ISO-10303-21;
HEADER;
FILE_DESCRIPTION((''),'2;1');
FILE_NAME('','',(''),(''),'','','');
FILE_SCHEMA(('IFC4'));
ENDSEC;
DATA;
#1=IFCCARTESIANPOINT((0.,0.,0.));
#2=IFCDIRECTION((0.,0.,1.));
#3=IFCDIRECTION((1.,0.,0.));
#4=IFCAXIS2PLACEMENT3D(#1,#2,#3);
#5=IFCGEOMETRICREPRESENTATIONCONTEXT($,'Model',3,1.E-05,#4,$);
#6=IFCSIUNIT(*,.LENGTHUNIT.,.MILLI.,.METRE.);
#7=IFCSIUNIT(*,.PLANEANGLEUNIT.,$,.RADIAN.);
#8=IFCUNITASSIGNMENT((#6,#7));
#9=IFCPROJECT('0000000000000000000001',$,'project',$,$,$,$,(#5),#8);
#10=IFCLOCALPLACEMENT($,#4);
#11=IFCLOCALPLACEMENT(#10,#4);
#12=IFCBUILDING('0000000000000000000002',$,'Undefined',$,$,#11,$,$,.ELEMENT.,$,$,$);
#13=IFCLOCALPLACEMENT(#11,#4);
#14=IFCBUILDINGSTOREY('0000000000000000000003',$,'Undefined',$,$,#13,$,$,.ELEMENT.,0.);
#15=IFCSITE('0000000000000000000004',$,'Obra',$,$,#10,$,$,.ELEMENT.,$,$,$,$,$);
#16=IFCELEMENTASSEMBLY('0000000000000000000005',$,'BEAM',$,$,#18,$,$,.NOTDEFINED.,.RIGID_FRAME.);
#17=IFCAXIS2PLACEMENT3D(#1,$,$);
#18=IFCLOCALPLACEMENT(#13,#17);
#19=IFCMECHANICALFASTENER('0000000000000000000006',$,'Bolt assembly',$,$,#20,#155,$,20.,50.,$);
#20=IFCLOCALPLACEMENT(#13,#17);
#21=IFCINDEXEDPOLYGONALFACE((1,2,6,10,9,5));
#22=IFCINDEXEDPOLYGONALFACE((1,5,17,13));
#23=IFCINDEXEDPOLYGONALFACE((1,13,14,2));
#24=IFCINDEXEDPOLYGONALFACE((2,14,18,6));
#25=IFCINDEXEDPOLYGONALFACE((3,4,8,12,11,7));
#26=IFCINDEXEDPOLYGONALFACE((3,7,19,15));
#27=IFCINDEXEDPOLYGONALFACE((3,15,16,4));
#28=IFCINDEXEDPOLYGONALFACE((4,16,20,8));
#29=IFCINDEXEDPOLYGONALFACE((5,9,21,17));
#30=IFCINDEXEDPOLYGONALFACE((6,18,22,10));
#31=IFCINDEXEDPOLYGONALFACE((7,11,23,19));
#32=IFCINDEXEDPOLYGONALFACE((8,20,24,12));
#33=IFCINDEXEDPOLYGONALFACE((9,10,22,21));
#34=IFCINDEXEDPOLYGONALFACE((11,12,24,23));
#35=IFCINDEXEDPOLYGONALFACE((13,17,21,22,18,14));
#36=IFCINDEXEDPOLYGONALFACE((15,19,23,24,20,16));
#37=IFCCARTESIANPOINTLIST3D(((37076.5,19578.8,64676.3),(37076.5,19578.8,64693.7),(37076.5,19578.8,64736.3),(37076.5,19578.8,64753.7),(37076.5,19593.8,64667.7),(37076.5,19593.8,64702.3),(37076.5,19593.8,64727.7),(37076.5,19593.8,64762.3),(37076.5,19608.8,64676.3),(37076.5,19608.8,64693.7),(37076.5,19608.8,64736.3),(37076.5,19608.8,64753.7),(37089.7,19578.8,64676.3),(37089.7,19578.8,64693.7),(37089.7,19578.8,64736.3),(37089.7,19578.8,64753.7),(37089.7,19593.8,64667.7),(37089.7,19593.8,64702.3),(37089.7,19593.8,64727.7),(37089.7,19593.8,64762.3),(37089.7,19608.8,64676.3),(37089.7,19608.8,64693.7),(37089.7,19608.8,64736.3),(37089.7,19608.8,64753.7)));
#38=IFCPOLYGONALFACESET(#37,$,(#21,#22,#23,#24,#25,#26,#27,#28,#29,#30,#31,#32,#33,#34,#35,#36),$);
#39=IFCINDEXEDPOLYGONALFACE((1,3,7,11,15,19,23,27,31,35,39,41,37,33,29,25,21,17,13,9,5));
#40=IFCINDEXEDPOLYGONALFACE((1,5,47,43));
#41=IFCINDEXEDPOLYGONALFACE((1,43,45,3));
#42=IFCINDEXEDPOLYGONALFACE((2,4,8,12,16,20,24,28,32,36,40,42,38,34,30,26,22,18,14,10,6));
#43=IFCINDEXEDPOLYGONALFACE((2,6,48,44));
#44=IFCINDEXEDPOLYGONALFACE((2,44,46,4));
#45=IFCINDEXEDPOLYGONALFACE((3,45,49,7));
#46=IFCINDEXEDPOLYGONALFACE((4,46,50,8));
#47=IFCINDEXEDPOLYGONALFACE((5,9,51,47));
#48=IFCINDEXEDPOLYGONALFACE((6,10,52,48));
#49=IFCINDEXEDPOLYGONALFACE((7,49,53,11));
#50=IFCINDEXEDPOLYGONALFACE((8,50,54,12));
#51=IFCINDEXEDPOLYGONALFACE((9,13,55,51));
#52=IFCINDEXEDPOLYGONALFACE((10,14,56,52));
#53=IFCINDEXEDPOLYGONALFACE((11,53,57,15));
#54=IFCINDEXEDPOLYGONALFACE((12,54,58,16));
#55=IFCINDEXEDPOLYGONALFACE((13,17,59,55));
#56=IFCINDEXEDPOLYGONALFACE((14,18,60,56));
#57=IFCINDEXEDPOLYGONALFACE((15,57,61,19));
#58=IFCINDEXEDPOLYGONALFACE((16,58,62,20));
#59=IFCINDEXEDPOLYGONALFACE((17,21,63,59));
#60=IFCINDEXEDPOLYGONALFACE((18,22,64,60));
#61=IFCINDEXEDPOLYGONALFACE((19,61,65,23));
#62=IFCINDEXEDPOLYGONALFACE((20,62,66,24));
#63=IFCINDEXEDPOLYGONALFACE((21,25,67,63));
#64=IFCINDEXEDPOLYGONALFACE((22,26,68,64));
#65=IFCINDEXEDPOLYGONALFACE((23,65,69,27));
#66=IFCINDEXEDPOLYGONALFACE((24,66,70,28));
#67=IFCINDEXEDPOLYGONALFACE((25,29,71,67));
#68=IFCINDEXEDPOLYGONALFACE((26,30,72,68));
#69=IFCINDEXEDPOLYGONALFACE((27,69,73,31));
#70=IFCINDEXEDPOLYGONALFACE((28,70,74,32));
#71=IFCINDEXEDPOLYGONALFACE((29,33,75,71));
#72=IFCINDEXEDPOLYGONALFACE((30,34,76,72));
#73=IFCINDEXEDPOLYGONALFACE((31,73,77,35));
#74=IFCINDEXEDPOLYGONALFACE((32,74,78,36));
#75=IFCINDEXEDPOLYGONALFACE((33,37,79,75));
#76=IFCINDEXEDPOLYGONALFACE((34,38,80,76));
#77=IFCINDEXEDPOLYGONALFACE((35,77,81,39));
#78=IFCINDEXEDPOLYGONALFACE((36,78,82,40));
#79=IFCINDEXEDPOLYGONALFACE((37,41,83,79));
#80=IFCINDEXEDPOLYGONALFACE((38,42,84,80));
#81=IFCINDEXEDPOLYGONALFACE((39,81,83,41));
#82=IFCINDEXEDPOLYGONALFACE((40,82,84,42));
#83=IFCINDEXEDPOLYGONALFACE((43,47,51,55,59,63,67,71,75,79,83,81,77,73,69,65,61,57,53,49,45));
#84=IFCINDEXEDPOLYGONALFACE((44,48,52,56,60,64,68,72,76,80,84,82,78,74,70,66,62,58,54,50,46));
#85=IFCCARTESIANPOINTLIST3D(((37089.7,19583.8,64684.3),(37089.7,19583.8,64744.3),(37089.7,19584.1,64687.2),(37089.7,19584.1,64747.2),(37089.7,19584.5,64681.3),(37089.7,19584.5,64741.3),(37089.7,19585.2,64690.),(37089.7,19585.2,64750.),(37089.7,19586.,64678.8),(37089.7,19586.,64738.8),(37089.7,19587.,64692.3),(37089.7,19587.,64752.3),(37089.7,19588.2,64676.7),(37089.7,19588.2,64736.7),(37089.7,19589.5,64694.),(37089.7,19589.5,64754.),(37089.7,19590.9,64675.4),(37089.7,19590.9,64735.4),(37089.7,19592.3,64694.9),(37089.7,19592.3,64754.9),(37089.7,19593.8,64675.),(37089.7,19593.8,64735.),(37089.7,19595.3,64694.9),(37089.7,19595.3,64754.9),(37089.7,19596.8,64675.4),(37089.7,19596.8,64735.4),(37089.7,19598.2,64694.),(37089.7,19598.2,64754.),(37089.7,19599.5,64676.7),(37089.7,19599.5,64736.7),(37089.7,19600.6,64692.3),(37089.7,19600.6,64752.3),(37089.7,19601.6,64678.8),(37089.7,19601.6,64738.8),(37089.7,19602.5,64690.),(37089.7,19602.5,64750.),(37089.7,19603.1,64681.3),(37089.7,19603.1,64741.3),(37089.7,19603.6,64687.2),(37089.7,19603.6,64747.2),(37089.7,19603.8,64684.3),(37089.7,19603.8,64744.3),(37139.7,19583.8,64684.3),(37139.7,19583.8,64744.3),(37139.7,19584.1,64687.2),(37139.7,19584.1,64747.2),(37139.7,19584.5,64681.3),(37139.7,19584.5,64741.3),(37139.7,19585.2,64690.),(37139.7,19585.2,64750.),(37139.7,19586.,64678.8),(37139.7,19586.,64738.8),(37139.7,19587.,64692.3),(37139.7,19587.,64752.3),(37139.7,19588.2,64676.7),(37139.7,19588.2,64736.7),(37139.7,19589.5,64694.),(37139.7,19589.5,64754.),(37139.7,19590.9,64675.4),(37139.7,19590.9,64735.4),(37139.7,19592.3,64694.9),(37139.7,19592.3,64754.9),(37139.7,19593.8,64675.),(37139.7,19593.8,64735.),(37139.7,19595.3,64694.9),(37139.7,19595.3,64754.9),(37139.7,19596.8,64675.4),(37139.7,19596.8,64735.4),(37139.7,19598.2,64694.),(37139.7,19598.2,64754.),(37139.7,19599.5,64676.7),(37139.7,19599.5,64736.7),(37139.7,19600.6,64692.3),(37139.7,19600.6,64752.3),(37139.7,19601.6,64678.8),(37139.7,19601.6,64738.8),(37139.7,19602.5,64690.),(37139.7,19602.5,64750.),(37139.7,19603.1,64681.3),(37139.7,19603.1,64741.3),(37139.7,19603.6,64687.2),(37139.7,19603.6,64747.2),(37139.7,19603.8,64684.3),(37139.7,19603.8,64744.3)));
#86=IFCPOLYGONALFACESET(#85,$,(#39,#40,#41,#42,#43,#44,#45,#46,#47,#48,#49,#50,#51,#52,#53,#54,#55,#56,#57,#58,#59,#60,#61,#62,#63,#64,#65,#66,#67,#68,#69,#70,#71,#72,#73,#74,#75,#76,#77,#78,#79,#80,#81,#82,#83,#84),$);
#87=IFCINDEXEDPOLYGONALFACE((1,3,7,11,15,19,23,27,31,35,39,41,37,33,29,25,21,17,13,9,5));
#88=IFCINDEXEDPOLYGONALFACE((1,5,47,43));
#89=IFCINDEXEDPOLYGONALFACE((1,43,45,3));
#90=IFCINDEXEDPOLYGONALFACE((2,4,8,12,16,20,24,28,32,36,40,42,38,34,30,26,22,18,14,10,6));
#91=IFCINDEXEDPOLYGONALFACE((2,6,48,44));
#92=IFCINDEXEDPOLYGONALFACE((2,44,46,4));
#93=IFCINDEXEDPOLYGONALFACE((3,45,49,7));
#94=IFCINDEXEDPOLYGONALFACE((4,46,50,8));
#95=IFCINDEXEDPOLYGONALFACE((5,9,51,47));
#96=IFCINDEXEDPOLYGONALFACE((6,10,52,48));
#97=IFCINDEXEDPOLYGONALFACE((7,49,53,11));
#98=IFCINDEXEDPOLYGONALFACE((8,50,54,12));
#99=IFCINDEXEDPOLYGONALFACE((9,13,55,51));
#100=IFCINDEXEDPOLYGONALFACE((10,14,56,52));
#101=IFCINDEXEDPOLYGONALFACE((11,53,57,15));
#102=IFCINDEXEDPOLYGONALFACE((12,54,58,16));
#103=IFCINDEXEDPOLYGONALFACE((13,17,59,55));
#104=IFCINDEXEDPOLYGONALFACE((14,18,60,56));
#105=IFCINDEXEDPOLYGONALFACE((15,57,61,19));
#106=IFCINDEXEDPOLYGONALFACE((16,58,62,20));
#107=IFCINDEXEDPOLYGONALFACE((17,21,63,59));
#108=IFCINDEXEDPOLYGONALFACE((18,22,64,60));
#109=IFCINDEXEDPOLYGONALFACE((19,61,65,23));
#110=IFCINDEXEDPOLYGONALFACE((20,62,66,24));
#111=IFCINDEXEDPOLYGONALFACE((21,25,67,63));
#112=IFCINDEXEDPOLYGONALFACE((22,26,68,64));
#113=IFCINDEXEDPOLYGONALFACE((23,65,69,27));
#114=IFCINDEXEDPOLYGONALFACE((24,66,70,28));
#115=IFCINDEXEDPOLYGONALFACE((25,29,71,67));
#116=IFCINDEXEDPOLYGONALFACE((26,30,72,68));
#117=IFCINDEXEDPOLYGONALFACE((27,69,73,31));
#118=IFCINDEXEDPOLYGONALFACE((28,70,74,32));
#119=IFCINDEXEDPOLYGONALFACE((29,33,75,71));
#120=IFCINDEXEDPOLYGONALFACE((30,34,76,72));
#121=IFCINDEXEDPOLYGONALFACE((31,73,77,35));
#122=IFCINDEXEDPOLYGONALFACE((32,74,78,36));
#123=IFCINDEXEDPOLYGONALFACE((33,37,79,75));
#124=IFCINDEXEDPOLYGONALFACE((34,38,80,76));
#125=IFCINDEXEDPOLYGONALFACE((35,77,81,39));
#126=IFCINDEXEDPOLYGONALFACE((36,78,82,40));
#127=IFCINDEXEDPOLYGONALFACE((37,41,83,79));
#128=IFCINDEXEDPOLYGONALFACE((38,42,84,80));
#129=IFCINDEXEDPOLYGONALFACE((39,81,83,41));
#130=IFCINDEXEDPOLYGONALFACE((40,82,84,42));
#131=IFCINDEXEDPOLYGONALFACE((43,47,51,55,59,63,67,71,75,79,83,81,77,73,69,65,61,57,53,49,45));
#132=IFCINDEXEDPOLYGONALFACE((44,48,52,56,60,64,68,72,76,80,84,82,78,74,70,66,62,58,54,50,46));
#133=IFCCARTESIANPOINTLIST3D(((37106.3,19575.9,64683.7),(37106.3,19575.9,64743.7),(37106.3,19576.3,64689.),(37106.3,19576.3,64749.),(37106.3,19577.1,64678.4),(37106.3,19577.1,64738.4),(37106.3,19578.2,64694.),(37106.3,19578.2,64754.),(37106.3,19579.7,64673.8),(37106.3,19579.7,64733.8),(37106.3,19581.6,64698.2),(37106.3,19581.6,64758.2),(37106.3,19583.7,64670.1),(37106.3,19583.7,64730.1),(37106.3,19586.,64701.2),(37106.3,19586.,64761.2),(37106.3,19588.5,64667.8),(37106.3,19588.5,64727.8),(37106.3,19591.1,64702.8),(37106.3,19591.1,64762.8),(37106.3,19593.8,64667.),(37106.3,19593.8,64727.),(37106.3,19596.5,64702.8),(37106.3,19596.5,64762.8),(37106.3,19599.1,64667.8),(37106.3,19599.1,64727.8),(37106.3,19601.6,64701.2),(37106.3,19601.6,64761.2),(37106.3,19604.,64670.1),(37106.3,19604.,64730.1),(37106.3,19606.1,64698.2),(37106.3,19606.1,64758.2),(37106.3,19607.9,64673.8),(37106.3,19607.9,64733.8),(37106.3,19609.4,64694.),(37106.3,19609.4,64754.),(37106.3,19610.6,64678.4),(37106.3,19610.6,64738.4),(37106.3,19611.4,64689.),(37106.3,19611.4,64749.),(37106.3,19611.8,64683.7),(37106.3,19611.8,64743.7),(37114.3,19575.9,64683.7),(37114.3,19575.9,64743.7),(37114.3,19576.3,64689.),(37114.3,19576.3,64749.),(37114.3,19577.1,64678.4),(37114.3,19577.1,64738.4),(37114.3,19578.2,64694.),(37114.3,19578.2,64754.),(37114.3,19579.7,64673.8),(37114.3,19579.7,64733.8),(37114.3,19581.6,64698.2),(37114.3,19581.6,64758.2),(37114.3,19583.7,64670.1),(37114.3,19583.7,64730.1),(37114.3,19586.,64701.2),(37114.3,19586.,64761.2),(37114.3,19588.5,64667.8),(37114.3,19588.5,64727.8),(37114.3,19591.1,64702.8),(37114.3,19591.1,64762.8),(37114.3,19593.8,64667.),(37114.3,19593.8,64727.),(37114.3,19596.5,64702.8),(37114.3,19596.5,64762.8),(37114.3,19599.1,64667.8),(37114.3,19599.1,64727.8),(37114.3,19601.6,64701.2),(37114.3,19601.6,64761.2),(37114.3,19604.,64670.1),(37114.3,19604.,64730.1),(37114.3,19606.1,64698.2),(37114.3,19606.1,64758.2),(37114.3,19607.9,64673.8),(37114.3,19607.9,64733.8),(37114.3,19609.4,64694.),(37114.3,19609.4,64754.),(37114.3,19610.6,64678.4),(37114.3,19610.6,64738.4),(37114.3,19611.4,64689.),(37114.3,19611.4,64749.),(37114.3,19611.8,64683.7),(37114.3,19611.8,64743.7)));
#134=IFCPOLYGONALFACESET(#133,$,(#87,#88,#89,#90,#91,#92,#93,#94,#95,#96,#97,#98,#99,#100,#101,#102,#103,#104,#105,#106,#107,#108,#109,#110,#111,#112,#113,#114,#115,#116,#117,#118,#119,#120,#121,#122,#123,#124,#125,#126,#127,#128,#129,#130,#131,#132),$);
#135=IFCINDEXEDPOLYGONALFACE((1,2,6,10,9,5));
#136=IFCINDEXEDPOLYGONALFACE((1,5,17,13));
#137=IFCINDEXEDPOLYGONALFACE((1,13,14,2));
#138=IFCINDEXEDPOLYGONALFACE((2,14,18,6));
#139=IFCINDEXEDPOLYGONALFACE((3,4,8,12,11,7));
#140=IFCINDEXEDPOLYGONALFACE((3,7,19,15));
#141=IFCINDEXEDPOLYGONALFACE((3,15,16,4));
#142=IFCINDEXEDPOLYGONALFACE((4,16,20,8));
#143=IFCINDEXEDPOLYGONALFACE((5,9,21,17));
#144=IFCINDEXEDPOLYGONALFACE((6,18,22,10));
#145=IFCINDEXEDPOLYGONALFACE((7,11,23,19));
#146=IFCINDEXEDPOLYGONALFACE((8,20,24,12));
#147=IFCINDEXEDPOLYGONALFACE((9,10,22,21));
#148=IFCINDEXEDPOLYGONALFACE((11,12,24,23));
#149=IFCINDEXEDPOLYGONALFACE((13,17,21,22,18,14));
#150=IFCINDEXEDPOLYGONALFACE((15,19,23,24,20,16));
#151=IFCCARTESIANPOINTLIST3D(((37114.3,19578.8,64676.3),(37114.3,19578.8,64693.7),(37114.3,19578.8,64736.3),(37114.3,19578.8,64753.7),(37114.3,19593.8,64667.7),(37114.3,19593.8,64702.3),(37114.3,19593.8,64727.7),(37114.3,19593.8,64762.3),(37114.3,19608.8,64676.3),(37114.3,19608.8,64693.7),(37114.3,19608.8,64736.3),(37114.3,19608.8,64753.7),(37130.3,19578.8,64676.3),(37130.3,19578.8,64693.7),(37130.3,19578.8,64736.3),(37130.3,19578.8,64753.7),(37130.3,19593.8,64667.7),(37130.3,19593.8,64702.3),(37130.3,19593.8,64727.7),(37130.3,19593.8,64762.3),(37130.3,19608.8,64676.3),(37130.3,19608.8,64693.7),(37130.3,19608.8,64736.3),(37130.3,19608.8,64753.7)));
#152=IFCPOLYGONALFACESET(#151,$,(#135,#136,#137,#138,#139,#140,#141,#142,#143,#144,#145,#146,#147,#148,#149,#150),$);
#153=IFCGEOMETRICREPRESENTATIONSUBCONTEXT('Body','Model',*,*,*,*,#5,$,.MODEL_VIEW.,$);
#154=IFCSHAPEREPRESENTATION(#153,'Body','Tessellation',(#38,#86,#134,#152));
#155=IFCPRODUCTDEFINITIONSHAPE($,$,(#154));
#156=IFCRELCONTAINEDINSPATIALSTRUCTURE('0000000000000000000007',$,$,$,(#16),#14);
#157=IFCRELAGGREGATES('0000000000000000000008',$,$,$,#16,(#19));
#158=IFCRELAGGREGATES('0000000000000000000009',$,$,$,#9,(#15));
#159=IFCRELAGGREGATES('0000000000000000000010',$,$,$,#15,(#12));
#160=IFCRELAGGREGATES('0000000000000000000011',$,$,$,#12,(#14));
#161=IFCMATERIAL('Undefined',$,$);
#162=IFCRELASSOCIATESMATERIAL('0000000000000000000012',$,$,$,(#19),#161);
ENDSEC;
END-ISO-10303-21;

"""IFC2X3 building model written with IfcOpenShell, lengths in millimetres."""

from ifc_helpers import new_model, si_unit, frame, origin_with_axes, origin_2d_with_axis, place, context, subcontext, project, spatial, polyline, circle, outline, extrude, source, transform, mapped, material, element, aggregate, save


model = new_model("IFC2X3")

# Units and contexts
model_context = context("Model", 3, precision=1e-05, world=origin_with_axes())
body_context = subcontext(model_context, "Body", "Model", "MODEL_VIEW")
ifc_project = project(units=[si_unit("LENGTHUNIT", "METRE", prefix="MILLI"), si_unit("PLANEANGLEUNIT", "RADIAN")], contexts=[model_context])

# Site, building, storey
site_placement = place(None, origin_with_axes())
site = spatial("IfcSite", under=ifc_project, at=site_placement, Name="Obra", CompositionType="ELEMENT")
building_placement = place(site_placement, origin_with_axes())
building = spatial("IfcBuilding", under=site, at=building_placement, Name="Undefined", CompositionType="ELEMENT")
storey_placement = place(building_placement, origin_with_axes())
storey = spatial("IfcBuildingStorey", under=building, at=storey_placement, Name="Undefined", CompositionType="ELEMENT", Elevation=0.0)

# Element assembly, mechanical fastener
ifc_material = material(Name="Undefined")
shared_shape_1 = source(origin_with_axes(), body_context, "Body", "SweptSolid", [
    extrude(outline(polyline([(17.3, 0.0), (8.7, 15.0), (-8.7, 15.0), (-17.3, 0.0), (-8.7, -15.0), (8.7, -15.0), (17.3, 0.0)])), frame((0.0, -26.5, 0.0), z_axis=(0.0, 1.0, 0.0), x_axis=(1.0, 0.0, 0.0)), (0.0, 0.0, 1.0), 13.2),
    extrude(circle(Radius=10.0, at=origin_2d_with_axis()), frame((0.0, -13.3, 0.0), z_axis=(0.0, 1.0, 0.0), x_axis=(1.0, 0.0, 0.0)), (0.0, 0.0, 1.0), 50.0),
    extrude(circle(Radius=18.0, at=origin_2d_with_axis()), frame((0.0, 3.3, 0.0), z_axis=(0.0, 1.0, 0.0), x_axis=(1.0, 0.0, 0.0)), (0.0, 0.0, 1.0), 8.0),
    extrude(outline(polyline([(17.3, 0.0), (8.7, 15.0), (-8.7, 15.0), (-17.3, 0.0), (-8.7, -15.0), (8.7, -15.0), (17.3, 0.0)])), frame((0.0, 11.3, 0.0), z_axis=(0.0, 1.0, 0.0), x_axis=(1.0, 0.0, 0.0)), (0.0, 0.0, 1.0), 16.0),
])
assembly_1_placement = place(storey_placement, origin_with_axes())
assembly_1 = element("IfcElementAssembly", 1, at=assembly_1_placement, inside=storey, Name="BEAM", AssemblyPlace="NOTDEFINED", PredefinedType="RIGID_FRAME")
mechanical_fastener_1_placement = place(assembly_1_placement, frame((37103.0, 19633.8, 64850.0), z_axis=(0.0, -1.0, 0.0), x_axis=(0.0, 0.0, -1.0)))
mechanical_fastener_1 = element("IfcMechanicalFastener", 2, at=mechanical_fastener_1_placement, material=ifc_material, Name="Bolt assembly", NominalDiameter=20.0, NominalLength=50.0, context=body_context, shape_type="MappedRepresentation", body=[
    mapped(shared_shape_1, transform((105.0, 0.0, 40.0))),
    mapped(shared_shape_1, transform((165.0, 0.0, 40.0))),
])

aggregate(assembly_1, [mechanical_fastener_1])

save(model, "model.ifc")
